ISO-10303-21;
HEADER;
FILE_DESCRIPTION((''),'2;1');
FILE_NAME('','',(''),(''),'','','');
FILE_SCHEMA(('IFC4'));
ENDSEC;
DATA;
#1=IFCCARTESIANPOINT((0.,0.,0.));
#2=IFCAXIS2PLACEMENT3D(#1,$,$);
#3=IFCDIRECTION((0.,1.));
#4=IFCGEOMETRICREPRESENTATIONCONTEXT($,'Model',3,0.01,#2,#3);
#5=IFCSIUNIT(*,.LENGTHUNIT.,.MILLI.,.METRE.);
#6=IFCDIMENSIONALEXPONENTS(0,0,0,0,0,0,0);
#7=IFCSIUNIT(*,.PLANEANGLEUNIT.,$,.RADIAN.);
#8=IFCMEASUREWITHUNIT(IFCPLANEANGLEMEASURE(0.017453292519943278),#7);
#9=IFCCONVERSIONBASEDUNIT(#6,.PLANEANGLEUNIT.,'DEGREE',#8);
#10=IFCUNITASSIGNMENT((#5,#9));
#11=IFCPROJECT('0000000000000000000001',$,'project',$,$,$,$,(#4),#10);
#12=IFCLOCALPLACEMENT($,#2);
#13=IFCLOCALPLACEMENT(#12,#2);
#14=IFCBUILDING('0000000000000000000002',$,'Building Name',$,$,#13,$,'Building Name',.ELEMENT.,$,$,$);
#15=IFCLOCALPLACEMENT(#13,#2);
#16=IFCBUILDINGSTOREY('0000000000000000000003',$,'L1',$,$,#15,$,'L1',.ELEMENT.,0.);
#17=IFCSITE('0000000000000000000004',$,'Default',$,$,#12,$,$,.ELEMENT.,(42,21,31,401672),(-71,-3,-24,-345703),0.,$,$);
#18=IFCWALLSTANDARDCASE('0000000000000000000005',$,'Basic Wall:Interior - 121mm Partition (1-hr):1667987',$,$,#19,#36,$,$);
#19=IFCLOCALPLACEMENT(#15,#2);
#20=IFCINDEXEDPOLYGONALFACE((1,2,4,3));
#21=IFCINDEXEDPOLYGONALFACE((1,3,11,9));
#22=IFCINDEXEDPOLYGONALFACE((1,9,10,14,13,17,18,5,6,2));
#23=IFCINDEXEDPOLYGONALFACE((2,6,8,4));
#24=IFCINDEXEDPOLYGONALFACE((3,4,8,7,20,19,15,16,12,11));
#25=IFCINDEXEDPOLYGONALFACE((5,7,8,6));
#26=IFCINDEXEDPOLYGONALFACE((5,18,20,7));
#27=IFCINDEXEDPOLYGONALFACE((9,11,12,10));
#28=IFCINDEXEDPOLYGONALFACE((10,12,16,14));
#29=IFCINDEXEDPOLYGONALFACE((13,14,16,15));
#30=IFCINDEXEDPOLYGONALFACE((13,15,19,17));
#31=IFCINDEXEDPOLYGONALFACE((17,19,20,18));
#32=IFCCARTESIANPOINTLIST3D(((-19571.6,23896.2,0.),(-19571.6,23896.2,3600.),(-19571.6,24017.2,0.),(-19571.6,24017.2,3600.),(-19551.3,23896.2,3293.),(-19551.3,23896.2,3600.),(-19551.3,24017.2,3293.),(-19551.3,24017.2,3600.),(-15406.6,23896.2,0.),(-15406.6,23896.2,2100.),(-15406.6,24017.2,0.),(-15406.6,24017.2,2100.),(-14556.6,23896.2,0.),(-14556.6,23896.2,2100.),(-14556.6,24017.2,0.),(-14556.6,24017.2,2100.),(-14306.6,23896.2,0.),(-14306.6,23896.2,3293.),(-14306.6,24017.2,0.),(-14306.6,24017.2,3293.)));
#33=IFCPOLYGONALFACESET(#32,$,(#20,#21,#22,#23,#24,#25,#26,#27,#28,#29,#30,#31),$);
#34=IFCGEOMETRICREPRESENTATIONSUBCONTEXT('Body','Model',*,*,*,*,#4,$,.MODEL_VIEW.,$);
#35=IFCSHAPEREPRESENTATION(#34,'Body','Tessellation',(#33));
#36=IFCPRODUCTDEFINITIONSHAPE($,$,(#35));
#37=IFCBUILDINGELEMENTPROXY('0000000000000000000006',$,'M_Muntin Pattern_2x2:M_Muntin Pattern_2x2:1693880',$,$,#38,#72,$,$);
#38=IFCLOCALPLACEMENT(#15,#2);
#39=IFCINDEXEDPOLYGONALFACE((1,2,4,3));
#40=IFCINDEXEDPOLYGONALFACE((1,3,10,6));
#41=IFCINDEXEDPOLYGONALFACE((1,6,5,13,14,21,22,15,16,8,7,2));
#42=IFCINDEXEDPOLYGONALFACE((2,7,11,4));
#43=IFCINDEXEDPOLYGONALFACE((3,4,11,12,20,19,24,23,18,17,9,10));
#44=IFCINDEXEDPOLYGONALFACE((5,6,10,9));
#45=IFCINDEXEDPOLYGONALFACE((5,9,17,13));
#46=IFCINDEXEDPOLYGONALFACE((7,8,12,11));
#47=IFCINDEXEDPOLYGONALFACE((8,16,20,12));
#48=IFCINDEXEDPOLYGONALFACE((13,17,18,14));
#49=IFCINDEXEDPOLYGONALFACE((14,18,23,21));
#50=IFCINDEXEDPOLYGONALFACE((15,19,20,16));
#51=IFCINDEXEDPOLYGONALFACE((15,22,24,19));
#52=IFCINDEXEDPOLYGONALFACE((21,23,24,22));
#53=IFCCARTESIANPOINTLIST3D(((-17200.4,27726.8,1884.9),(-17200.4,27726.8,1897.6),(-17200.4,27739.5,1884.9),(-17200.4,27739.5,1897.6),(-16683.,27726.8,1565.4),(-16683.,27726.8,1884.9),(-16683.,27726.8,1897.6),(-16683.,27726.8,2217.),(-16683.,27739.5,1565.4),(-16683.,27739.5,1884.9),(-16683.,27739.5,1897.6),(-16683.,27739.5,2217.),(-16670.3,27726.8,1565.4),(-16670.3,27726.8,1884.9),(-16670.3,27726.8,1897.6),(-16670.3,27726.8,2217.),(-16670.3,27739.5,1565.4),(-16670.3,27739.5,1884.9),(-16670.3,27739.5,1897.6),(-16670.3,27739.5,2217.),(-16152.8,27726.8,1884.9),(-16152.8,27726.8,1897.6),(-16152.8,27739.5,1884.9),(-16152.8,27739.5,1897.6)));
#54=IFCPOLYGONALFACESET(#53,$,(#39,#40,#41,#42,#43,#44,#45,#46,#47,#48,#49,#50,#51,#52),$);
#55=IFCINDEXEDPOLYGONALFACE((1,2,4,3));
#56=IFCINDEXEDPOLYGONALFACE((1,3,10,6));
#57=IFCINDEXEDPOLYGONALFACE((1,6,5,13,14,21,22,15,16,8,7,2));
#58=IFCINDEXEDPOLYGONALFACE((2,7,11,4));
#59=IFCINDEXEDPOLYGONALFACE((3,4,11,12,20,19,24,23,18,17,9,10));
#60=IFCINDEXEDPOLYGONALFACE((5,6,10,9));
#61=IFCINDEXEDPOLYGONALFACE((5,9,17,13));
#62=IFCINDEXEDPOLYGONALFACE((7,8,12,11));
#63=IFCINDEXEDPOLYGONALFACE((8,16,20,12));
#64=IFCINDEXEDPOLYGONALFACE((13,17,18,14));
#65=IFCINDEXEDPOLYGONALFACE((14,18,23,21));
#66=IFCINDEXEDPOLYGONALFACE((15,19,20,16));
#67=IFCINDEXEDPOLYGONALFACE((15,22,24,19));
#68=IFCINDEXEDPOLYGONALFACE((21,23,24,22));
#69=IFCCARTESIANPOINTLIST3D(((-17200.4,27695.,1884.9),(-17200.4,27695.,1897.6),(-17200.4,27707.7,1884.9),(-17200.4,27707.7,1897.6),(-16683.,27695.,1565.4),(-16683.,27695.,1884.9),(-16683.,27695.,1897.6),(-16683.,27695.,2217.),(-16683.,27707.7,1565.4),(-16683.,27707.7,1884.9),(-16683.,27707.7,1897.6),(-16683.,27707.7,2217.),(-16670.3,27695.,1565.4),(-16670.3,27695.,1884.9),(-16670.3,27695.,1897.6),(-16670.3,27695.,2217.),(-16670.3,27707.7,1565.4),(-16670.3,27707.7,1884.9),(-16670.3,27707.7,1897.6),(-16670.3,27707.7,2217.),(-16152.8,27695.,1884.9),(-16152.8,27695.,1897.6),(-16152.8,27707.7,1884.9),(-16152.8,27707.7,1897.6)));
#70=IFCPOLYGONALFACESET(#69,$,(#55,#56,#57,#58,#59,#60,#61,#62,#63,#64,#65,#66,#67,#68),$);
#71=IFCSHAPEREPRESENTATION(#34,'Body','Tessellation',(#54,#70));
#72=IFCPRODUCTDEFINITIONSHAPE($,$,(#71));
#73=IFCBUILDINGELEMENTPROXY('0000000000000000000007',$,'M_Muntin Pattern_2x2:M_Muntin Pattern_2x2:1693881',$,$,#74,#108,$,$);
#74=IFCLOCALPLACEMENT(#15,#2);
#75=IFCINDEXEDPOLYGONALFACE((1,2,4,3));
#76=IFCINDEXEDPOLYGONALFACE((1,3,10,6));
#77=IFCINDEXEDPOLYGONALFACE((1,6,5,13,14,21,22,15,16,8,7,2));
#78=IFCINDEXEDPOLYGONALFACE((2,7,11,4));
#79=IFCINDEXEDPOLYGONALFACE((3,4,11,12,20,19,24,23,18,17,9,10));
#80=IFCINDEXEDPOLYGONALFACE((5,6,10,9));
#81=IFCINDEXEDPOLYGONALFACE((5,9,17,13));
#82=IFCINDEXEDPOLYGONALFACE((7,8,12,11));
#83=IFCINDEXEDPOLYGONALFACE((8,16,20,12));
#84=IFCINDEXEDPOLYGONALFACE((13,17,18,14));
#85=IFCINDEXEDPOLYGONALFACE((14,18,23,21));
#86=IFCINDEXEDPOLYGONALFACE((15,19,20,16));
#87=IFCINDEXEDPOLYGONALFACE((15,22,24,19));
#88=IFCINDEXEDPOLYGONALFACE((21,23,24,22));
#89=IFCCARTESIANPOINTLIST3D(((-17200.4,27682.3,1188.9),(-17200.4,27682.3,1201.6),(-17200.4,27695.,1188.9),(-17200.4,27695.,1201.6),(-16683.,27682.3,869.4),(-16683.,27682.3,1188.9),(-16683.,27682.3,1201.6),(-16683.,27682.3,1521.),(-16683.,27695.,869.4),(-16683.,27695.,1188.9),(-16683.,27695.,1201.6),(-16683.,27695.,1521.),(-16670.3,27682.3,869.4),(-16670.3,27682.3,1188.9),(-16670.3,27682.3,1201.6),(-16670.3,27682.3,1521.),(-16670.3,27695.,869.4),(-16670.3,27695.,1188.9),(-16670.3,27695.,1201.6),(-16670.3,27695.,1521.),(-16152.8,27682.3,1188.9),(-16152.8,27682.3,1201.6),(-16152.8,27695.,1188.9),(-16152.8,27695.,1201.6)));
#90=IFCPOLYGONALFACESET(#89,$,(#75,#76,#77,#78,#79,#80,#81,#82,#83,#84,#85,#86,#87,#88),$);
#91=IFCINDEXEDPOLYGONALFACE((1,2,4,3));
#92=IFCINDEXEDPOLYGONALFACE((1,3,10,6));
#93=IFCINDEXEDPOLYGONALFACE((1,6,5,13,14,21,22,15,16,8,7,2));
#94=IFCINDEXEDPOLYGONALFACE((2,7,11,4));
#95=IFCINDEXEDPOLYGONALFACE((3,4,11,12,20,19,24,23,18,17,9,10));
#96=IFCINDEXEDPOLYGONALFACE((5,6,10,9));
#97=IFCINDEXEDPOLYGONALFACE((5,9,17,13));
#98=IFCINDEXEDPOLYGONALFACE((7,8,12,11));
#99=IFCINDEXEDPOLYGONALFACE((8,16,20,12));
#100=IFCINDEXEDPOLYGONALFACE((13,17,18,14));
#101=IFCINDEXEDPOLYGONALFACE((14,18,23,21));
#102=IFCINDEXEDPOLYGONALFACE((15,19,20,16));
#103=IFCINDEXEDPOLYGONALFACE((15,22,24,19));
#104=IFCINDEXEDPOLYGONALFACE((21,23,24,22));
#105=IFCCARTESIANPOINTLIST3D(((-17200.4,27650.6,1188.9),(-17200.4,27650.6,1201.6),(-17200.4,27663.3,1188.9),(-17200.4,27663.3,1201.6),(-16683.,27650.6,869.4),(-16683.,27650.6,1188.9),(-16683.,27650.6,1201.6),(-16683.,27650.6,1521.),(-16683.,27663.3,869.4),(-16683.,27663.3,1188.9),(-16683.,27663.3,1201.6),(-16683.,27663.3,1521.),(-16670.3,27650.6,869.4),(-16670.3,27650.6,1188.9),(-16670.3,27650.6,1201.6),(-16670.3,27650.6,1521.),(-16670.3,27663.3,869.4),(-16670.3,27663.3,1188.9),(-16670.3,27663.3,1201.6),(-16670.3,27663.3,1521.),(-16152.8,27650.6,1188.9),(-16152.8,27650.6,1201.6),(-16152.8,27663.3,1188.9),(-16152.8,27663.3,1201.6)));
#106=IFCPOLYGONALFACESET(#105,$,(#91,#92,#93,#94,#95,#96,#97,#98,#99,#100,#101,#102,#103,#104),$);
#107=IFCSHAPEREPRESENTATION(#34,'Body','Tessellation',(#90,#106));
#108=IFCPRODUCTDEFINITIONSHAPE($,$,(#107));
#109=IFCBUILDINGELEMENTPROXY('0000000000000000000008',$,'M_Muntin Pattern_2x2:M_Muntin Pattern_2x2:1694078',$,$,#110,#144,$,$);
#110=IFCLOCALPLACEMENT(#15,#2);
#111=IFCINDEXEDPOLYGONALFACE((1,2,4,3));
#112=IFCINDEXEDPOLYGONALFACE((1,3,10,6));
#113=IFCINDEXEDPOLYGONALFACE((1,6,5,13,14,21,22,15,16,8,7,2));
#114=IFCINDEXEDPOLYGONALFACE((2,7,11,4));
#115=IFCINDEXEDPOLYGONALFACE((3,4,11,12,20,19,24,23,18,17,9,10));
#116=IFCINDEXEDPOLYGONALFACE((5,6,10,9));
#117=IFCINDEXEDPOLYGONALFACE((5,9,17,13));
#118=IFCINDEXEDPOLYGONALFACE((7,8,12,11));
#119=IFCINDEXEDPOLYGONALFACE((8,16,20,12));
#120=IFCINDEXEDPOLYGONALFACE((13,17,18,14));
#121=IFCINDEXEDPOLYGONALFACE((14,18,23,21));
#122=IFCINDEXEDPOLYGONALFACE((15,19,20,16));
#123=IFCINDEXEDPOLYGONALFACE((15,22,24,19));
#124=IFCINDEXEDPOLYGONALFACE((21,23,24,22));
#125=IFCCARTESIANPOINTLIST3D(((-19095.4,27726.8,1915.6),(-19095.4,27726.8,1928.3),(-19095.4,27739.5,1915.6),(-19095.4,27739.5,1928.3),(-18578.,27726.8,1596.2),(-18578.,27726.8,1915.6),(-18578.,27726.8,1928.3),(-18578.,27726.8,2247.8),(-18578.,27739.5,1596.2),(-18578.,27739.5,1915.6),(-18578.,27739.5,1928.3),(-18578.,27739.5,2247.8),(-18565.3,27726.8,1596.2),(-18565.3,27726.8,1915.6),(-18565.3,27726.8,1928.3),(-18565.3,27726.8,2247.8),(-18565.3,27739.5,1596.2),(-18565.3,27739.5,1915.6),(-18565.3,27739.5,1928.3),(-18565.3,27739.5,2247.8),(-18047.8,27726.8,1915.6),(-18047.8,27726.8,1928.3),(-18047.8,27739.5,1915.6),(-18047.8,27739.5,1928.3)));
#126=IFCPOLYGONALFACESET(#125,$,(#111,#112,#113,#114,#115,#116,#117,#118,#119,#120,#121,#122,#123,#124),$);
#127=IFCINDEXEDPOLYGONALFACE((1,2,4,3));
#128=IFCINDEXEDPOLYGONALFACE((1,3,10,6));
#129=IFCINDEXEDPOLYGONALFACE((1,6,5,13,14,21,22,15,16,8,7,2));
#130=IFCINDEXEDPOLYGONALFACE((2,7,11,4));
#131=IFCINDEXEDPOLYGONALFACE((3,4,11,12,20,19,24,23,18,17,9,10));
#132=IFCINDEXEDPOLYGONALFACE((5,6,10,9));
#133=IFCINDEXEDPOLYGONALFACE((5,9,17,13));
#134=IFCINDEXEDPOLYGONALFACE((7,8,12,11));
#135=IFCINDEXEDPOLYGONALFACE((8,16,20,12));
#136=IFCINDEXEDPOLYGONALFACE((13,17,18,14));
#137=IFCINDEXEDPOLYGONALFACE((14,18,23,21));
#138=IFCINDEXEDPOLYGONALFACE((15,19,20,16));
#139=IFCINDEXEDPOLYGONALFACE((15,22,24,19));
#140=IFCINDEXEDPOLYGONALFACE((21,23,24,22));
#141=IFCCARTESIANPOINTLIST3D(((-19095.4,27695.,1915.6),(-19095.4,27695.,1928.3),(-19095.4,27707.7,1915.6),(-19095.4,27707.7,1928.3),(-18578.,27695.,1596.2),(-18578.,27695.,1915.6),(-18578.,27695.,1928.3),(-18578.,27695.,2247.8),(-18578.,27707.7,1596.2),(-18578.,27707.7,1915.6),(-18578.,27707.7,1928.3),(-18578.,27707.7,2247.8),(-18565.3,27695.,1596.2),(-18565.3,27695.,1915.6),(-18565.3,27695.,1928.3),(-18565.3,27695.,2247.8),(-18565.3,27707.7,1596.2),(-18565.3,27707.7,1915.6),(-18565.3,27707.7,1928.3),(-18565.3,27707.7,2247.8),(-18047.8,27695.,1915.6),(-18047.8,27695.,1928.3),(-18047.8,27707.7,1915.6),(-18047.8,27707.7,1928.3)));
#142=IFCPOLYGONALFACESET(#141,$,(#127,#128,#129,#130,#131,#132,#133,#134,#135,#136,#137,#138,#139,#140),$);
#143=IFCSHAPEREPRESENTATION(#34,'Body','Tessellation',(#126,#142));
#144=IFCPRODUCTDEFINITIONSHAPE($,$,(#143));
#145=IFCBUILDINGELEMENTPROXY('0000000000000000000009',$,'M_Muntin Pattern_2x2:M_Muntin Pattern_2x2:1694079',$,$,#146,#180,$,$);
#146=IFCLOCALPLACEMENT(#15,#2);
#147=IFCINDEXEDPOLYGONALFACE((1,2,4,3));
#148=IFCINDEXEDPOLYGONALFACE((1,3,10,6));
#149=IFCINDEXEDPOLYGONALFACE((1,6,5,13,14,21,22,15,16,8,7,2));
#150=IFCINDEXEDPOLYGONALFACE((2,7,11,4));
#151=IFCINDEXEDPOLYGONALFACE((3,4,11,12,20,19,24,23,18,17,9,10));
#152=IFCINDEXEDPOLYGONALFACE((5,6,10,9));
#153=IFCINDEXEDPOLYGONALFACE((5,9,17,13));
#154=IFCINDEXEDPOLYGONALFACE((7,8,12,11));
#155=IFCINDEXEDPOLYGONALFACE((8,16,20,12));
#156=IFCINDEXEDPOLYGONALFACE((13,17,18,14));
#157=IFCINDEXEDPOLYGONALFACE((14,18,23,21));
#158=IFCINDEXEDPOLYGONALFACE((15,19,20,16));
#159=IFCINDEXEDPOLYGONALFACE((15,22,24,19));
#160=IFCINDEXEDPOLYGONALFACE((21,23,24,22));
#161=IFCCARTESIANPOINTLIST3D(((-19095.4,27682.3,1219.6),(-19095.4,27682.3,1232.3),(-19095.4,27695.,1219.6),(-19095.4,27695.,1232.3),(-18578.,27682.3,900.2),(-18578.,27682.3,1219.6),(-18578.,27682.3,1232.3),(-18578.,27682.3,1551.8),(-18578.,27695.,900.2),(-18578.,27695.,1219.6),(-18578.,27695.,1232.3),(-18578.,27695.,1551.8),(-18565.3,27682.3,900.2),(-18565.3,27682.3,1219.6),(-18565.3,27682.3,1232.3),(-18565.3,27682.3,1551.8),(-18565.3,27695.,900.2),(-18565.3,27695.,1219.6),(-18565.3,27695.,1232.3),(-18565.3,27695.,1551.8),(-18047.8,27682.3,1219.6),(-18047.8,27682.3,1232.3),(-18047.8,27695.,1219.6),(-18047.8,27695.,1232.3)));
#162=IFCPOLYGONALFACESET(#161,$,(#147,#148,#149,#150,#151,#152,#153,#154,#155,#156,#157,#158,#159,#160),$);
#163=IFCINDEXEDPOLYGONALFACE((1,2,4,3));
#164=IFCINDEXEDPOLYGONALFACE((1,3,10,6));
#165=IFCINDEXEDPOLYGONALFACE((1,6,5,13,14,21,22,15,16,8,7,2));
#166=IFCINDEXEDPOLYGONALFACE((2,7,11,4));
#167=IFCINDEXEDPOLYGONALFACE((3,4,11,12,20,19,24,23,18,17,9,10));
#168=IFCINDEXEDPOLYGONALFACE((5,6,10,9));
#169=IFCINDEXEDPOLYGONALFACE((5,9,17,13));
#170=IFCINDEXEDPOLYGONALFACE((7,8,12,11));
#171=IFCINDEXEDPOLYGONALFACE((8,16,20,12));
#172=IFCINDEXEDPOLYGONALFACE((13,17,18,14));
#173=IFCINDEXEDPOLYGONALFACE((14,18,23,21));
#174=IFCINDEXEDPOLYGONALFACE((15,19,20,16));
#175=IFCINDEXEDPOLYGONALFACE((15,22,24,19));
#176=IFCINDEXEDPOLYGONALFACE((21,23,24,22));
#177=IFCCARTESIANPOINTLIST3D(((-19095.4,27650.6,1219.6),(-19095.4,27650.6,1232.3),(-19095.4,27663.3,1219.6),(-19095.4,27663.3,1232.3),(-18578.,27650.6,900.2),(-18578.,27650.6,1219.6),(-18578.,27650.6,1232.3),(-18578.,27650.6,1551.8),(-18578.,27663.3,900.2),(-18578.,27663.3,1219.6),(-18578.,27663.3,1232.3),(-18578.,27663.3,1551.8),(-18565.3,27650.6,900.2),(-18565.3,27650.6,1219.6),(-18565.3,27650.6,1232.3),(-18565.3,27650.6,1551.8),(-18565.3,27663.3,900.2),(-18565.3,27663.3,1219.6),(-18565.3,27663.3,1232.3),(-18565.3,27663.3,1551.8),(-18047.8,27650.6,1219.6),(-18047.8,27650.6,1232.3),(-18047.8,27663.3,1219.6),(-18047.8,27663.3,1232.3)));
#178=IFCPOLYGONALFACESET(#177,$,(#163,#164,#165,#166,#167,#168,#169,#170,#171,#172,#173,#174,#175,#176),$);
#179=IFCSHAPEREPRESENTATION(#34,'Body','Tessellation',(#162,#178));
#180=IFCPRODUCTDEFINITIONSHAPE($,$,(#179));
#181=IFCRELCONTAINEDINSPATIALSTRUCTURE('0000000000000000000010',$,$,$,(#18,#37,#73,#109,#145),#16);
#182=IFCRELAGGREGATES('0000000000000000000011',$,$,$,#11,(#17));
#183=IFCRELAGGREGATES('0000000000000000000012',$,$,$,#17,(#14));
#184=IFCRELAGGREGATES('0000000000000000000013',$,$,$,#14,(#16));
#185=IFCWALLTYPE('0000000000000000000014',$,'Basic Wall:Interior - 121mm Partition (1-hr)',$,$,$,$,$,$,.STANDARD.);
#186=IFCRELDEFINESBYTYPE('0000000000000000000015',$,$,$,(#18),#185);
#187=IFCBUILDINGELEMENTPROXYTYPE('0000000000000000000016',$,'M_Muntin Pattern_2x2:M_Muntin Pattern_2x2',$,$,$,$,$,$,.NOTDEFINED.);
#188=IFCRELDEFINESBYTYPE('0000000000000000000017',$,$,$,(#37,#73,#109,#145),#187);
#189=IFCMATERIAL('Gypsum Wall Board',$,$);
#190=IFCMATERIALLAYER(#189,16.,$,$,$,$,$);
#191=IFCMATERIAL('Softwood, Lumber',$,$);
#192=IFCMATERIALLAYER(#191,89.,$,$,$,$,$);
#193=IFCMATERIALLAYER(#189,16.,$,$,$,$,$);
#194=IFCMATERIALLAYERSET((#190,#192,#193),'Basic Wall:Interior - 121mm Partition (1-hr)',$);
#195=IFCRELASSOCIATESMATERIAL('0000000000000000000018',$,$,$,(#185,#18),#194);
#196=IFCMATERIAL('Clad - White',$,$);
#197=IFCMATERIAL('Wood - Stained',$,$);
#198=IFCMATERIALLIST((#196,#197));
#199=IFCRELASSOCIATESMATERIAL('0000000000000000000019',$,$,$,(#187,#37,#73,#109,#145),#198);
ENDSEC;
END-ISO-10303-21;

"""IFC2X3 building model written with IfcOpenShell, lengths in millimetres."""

from ifc_helpers import new_model, entity, si_unit, converted_unit, direction, frame, frame_2d, origin, place, context, subcontext, project, spatial, polyline, rectangle, outline, extrude, clip, bounded_halfspace, source, transform, mapped, material, material_list, layer, layer_set, layer_usage, type_object, type_shapes, element, save


model = new_model("IFC2X3")

# Units and contexts
model_context = context("Model", 3, precision=0.01, world=origin(), true_north=direction((0.0, 1.0)))
body_context = subcontext(model_context, "Body", "Model", "MODEL_VIEW")
ifc_project = project(units=[si_unit("LENGTHUNIT", "METRE", prefix="MILLI"), converted_unit("PLANEANGLEUNIT", "DEGREE", entity("IfcPlaneAngleMeasure", 0.017453292519943278), si_unit("PLANEANGLEUNIT", "RADIAN"), dimensions=[0, 0, 0, 0, 0, 0, 0])], contexts=[model_context])

# Site, building, storey
site_placement = place(None, origin())
site = spatial("IfcSite", under=ifc_project, at=site_placement, Name="Default", CompositionType="ELEMENT", RefLatitude=(42, 21, 31, 401672), RefLongitude=(-71, -3, -24, -345703), RefElevation=0.0)
building_placement = place(site_placement, origin())
building = spatial("IfcBuilding", under=site, at=building_placement, Name="Building Name", LongName="Building Name", CompositionType="ELEMENT")
storey_placement = place(building_placement, origin())
storey = spatial("IfcBuildingStorey", under=building, at=storey_placement, Name="L1", LongName="L1", CompositionType="ELEMENT", Elevation=0.0)

# Shared definitions
ifc_material_1 = material(Name="Gypsum Wall Board")

# Shared definitions
ifc_material_2 = material(Name="Wood - Stained")

# Wall, opening
ifc_layer_1 = layer(ifc_material_1, 16.0)
ifc_material_3 = material(Name="Softwood, Lumber")
ifc_layer_2 = layer(ifc_material_3, 89.0)
ifc_layer_3 = layer(ifc_material_1, 16.0)
ifc_layer_set_1 = layer_set([ifc_layer_1, ifc_layer_2, ifc_layer_3], Name="Basic Wall:Interior - 121mm Partition (1-hr)")
ifc_layer_usage_1 = layer_usage(ifc_layer_set_1, "AXIS2", "NEGATIVE", 60.5)
wall_type_1 = type_object("IfcWallType", Name="Basic Wall:Interior - 121mm Partition (1-hr)", PredefinedType="STANDARD", material=ifc_layer_set_1)
wall_1_placement = place(storey_placement, frame((-19571.6, 23956.7, 0.0)))
wall_1 = element("IfcWallStandardCase", 1, at=wall_1_placement, inside=storey, type_object=wall_type_1, material=ifc_layer_usage_1, Name="Basic Wall:Interior - 121mm Partition (1-hr):1667987", context=body_context, shape_type="Clipping", body=[
    clip(extrude(rectangle(XDim=5265.0, YDim=121.0, at=frame_2d((2632.5, 0.0), x_axis=(-1.0, 0.0))), origin(), (0.0, 0.0, 1.0), 3600.0), bounded_halfspace(frame((20.3, -60.5, 3293.0), z_axis=(0.0, 0.0, -1.0), x_axis=(0.0, -1.0, 0.0)), True, frame((20.3, -60.5, 3293.0)), polyline([(0.0, 0.0), (5123.7, 0.0), (5244.7, 0.0), (5244.7, 121.0), (0.0, 121.0), (0.0, 0.0)]))),
])
opening_1_placement = place(wall_1_placement, frame((5015.0, 60.5, 0.0)))
element("IfcOpeningElement", 2, at=opening_1_placement, cuts=wall_1, ObjectType="Opening", context=body_context, shape_type="SweptSolid", body=[
    extrude(rectangle(XDim=2100.0, YDim=850.0, at=frame_2d((1050.0, 425.0), x_axis=(1.0, 0.0))), frame((0.0, 0.0, 0.0), z_axis=(0.0, -1.0, 0.0), x_axis=(0.0, 0.0, 1.0)), (0.0, 0.0, 1.0), 121.0),
])

# Building element proxies
ifc_material_4 = material(Name="Clad - White")
ifc_material_list_1 = material_list([ifc_material_4, ifc_material_2])
building_element_proxy_type_1 = type_object("IfcBuildingElementProxyType", Name="M_Muntin Pattern_2x2:M_Muntin Pattern_2x2", PredefinedType="NOTDEFINED", material=ifc_material_list_1)
shared_shape_1 = source(origin(), body_context, "Body", "SweptSolid", [
    extrude(outline(polyline([(6.4, -6.4), (325.8, -6.4), (325.8, 6.3), (6.4, 6.3), (6.4, 523.8), (-6.3, 523.8), (-6.3, 6.3), (-325.8, 6.3), (-325.8, -6.4), (-6.3, -6.4), (-6.3, -523.8), (6.4, -523.8), (6.4, -6.4)])), frame((0.0, 9.5, 325.8), z_axis=(0.0, 1.0, 0.0), x_axis=(0.0, 0.0, 1.0)), (0.0, 0.0, 1.0), 12.7),
    extrude(outline(polyline([(6.4, -6.4), (325.8, -6.4), (325.8, 6.3), (6.4, 6.3), (6.4, 523.8), (-6.3, 523.8), (-6.3, 6.3), (-325.8, 6.3), (-325.8, -6.4), (-6.3, -6.4), (-6.3, -523.8), (6.4, -523.8), (6.4, -6.4)])), frame((0.0, -22.2, 325.8), z_axis=(0.0, 1.0, 0.0), x_axis=(0.0, 0.0, 1.0)), (0.0, 0.0, 1.0), 12.7),
])
type_shapes(building_element_proxy_type_1, [shared_shape_1])
for number, where, name in (
    (3, (-16676.6, 27717.2, 1565.4), "M_Muntin Pattern_2x2:M_Muntin Pattern_2x2:1693880"),
    (4, (-16676.6, 27672.8, 869.4), "M_Muntin Pattern_2x2:M_Muntin Pattern_2x2:1693881"),
    (5, (-18571.6, 27717.2, 1596.2), "M_Muntin Pattern_2x2:M_Muntin Pattern_2x2:1694078"),
    (6, (-18571.6, 27672.8, 900.2), "M_Muntin Pattern_2x2:M_Muntin Pattern_2x2:1694079"),
):
    element("IfcBuildingElementProxy", number, at=place(storey_placement, frame(where)), inside=storey, type_object=building_element_proxy_type_1, material=ifc_material_list_1, Name=name, context=body_context, shape_type="MappedRepresentation", body=[
        mapped(shared_shape_1, transform((0.0, 0.0, 0.0), scale=1.0)),
    ])

save(model, "model.ifc")
